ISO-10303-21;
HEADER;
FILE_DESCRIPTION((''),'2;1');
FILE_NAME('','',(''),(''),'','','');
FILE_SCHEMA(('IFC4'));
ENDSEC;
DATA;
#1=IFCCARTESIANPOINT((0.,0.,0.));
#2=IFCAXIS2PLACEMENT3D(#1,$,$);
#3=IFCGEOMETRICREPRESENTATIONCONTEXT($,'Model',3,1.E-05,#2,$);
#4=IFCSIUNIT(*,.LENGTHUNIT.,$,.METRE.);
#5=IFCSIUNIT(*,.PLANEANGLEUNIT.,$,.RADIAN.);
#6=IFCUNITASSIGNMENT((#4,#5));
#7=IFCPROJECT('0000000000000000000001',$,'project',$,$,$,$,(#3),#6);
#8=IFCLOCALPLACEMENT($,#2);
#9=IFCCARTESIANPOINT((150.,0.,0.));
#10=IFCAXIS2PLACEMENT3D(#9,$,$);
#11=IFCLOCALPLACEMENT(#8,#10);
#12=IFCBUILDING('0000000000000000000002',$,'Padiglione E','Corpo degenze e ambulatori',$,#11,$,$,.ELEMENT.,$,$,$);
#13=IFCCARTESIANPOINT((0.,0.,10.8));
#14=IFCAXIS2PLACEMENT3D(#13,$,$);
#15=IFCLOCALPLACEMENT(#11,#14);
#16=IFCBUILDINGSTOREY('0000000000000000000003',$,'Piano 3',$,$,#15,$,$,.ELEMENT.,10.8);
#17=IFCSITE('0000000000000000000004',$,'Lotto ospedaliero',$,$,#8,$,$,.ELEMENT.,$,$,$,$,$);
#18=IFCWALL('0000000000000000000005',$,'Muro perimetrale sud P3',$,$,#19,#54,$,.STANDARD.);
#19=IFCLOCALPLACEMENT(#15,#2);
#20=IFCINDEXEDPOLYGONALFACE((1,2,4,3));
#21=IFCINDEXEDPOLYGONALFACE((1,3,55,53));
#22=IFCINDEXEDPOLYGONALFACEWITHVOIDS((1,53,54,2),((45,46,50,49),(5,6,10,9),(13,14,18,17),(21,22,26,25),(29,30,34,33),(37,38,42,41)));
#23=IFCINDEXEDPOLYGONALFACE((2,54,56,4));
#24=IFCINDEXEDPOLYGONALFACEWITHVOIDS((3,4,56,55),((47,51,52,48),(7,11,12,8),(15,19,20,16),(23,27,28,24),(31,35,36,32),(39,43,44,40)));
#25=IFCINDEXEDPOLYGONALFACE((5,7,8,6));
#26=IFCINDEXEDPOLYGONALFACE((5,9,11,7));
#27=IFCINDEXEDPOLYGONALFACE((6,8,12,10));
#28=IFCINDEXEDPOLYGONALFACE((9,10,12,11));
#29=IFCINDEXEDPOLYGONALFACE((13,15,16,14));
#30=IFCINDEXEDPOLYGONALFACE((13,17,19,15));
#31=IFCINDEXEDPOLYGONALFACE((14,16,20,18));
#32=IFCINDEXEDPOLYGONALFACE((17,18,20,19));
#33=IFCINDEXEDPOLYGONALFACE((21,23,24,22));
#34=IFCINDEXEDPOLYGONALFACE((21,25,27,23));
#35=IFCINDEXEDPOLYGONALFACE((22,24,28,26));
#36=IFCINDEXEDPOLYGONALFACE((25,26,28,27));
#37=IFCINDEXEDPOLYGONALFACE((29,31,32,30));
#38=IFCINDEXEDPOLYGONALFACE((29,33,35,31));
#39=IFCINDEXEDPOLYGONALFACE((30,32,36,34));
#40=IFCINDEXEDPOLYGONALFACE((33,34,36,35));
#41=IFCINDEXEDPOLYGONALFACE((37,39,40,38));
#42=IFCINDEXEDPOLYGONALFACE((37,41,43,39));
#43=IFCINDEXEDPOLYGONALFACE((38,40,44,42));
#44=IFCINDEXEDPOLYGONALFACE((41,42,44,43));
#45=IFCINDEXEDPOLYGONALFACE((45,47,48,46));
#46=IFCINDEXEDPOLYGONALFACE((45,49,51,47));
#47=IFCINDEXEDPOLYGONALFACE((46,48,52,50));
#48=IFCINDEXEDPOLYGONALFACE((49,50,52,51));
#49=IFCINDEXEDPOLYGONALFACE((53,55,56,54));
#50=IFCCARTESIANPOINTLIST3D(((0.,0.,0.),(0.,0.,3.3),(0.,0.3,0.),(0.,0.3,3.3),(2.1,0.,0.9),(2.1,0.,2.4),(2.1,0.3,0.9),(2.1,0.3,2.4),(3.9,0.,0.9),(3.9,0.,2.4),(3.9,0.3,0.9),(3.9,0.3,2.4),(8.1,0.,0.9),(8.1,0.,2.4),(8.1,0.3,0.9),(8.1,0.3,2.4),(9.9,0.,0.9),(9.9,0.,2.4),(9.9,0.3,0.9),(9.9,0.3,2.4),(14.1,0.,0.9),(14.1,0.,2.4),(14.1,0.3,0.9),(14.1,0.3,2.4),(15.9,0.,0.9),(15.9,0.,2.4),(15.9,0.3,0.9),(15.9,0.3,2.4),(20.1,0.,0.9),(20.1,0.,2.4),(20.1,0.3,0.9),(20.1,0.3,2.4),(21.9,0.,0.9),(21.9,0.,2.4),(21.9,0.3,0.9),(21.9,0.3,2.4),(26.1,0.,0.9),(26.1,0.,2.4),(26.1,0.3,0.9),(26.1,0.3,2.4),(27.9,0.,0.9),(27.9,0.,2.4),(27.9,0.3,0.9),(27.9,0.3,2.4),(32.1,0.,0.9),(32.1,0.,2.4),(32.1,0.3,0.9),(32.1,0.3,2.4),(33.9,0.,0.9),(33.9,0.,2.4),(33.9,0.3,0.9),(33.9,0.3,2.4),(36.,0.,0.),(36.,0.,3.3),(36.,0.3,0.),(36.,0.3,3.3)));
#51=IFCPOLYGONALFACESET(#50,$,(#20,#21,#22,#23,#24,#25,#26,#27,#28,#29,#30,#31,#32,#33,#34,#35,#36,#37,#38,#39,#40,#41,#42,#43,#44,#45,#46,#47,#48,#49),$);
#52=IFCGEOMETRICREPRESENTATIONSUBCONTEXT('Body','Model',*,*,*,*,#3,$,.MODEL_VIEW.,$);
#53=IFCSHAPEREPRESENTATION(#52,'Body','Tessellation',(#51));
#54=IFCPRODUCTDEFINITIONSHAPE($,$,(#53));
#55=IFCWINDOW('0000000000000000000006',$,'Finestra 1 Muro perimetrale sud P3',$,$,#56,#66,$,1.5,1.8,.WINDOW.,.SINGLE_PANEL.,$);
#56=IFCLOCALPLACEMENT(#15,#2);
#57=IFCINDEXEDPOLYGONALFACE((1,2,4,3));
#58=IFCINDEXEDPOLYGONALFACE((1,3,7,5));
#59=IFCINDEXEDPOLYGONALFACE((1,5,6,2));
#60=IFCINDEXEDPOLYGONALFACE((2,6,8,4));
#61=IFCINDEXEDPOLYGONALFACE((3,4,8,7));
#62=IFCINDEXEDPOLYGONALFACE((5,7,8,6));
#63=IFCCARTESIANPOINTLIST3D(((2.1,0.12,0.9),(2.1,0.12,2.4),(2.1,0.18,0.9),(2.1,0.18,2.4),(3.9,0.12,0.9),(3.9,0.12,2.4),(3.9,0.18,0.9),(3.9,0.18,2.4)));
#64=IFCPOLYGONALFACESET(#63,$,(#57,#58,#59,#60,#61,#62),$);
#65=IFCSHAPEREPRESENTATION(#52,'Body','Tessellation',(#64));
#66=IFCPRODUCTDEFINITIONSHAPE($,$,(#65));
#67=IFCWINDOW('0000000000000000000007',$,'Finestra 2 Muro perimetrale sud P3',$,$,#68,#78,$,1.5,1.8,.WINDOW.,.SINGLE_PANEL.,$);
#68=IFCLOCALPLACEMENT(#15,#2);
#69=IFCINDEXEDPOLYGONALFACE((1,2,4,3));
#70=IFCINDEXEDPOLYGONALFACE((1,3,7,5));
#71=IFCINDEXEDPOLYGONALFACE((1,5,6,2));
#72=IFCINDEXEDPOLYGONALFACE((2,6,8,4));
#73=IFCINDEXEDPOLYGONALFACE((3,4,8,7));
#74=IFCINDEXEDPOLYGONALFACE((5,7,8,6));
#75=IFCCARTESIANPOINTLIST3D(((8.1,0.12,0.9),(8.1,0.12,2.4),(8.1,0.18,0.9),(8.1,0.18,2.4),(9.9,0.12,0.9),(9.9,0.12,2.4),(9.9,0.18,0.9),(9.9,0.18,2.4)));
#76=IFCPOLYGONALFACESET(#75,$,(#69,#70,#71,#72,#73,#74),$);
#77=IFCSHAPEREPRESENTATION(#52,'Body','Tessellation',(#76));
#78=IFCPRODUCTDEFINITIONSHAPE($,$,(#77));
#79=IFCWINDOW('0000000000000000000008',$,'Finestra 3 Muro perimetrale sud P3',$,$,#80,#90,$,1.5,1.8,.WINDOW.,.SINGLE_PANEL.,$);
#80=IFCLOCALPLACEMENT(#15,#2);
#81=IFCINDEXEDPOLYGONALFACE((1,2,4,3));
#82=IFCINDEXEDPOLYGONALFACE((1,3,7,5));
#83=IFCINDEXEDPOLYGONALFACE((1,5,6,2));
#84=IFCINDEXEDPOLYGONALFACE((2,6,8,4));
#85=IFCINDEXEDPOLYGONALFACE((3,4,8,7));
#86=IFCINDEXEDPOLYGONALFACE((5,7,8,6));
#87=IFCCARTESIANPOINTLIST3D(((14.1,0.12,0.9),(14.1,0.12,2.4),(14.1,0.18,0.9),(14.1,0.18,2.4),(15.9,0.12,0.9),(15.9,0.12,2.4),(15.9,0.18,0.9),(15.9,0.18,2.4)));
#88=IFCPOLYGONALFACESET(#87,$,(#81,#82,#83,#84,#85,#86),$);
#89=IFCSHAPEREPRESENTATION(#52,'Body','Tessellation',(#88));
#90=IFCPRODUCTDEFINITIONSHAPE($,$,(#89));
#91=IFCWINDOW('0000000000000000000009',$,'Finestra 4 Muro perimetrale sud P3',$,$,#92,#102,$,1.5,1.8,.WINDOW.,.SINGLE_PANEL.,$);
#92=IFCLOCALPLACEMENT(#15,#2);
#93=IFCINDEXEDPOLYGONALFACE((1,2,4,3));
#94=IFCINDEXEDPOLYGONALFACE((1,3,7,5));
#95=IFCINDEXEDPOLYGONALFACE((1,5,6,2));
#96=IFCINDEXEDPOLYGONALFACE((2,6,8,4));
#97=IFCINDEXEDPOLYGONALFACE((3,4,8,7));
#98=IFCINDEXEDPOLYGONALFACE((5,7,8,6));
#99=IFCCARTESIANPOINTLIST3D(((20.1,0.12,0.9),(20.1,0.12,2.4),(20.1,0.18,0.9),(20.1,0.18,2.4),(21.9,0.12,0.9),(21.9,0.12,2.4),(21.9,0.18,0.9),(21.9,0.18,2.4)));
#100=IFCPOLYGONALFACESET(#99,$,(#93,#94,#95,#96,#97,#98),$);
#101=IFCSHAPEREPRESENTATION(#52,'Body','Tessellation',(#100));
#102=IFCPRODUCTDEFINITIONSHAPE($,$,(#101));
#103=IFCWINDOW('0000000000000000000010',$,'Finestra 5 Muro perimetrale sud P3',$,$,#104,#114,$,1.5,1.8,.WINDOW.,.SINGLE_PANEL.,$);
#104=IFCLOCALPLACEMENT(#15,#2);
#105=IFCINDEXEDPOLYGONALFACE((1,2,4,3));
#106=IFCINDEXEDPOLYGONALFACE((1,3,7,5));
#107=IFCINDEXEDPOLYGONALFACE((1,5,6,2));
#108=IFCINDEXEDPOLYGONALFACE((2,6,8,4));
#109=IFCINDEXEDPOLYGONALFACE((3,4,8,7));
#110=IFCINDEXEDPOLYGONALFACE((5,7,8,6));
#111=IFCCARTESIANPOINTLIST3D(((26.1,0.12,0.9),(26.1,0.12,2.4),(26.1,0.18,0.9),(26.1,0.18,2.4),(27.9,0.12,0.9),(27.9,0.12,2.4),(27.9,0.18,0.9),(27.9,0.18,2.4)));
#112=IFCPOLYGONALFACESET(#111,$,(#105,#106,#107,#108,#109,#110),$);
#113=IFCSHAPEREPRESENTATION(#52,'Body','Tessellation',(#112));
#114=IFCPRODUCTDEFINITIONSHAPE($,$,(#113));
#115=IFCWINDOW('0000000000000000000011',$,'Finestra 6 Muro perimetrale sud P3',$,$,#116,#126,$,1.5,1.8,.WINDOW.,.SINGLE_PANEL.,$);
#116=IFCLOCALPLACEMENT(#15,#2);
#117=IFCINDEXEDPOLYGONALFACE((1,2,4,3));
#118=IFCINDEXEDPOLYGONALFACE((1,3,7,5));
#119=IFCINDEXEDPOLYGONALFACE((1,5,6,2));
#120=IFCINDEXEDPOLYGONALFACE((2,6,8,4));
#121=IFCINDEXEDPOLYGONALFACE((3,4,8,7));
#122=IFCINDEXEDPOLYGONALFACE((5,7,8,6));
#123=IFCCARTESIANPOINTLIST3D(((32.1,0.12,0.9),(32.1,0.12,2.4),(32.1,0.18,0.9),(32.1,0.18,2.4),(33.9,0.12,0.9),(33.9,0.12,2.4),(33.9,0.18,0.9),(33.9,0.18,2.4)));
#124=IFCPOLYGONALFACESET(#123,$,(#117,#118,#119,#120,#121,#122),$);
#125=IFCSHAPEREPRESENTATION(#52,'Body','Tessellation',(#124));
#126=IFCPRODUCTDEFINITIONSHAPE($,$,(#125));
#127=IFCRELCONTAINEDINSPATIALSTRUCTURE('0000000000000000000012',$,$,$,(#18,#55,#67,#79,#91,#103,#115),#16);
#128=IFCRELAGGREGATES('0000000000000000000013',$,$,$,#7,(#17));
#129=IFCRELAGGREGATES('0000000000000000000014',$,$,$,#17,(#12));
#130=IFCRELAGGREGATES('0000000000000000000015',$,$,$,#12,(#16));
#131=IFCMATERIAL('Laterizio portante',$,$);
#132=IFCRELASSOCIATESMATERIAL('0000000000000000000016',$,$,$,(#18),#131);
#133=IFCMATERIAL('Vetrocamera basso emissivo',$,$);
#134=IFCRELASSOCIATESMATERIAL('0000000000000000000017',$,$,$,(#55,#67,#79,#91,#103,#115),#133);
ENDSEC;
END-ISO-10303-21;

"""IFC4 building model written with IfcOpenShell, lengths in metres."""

from ifc_helpers import new_model, si_unit, frame, frame_2d, origin, place, context, subcontext, project, spatial, rectangle, extrude, material, element, fill, save


model = new_model("IFC4")

# Units and contexts
model_context = context("Model", 3, precision=1e-05, world=origin())
body_context = subcontext(model_context, "Body", "Model", "MODEL_VIEW")
ifc_project = project(units=[si_unit("LENGTHUNIT", "METRE"), si_unit("PLANEANGLEUNIT", "RADIAN")], contexts=[model_context])

# Site, building, storey
site_placement = place(None, origin())
site = spatial("IfcSite", under=ifc_project, at=site_placement, Name="Lotto ospedaliero", CompositionType="ELEMENT")
building_placement = place(site_placement, frame((150.0, 0.0, 0.0)))
building = spatial("IfcBuilding", under=site, at=building_placement, Name="Padiglione E", Description="Corpo degenze e ambulatori", CompositionType="ELEMENT")
storey_placement = place(building_placement, frame((0.0, 0.0, 10.8)))
storey = spatial("IfcBuildingStorey", under=building, at=storey_placement, Name="Piano 3", CompositionType="ELEMENT", Elevation=10.8)

# Wall, openings, windows
ifc_material_1 = material(Name="Laterizio portante")
wall_1_placement = place(storey_placement, origin())
wall_1 = element("IfcWall", 1, at=wall_1_placement, inside=storey, material=ifc_material_1, Name="Muro perimetrale sud P3", PredefinedType="STANDARD", context=body_context, shape_type="SweptSolid", body=[
    extrude(rectangle(XDim=36.0, YDim=0.3, at=frame_2d((18.0, 0.15))), origin(), (0.0, 0.0, 1.0), 3.3),
])
opening_1_placement = place(wall_1_placement, frame((2.1, -0.1, 0.9)))
opening_1 = element("IfcOpeningElement", 2, at=opening_1_placement, cuts=wall_1, PredefinedType="OPENING", context=body_context, shape_type="SweptSolid", body=[
    extrude(rectangle(XDim=1.8, YDim=0.5, at=frame_2d((0.9, 0.25))), origin(), (0.0, 0.0, 1.0), 1.5),
])
opening_2_placement = place(wall_1_placement, frame((8.1, -0.1, 0.9)))
opening_2 = element("IfcOpeningElement", 3, at=opening_2_placement, cuts=wall_1, PredefinedType="OPENING", context=body_context, shape_type="SweptSolid", body=[
    extrude(rectangle(XDim=1.8, YDim=0.5, at=frame_2d((0.9, 0.25))), origin(), (0.0, 0.0, 1.0), 1.5),
])
opening_3_placement = place(wall_1_placement, frame((14.1, -0.1, 0.9)))
opening_3 = element("IfcOpeningElement", 4, at=opening_3_placement, cuts=wall_1, PredefinedType="OPENING", context=body_context, shape_type="SweptSolid", body=[
    extrude(rectangle(XDim=1.8, YDim=0.5, at=frame_2d((0.9, 0.25))), origin(), (0.0, 0.0, 1.0), 1.5),
])
opening_4_placement = place(wall_1_placement, frame((20.1, -0.1, 0.9)))
opening_4 = element("IfcOpeningElement", 5, at=opening_4_placement, cuts=wall_1, PredefinedType="OPENING", context=body_context, shape_type="SweptSolid", body=[
    extrude(rectangle(XDim=1.8, YDim=0.5, at=frame_2d((0.9, 0.25))), origin(), (0.0, 0.0, 1.0), 1.5),
])
opening_5_placement = place(wall_1_placement, frame((26.1, -0.1, 0.9)))
opening_5 = element("IfcOpeningElement", 6, at=opening_5_placement, cuts=wall_1, PredefinedType="OPENING", context=body_context, shape_type="SweptSolid", body=[
    extrude(rectangle(XDim=1.8, YDim=0.5, at=frame_2d((0.9, 0.25))), origin(), (0.0, 0.0, 1.0), 1.5),
])
opening_6_placement = place(wall_1_placement, frame((32.1, -0.1, 0.9)))
opening_6 = element("IfcOpeningElement", 7, at=opening_6_placement, cuts=wall_1, PredefinedType="OPENING", context=body_context, shape_type="SweptSolid", body=[
    extrude(rectangle(XDim=1.8, YDim=0.5, at=frame_2d((0.9, 0.25))), origin(), (0.0, 0.0, 1.0), 1.5),
])
ifc_material_2 = material(Name="Vetrocamera basso emissivo")
window_1_placement = place(wall_1_placement, frame((2.1, 0.12, 0.9)))
window_1 = element("IfcWindow", 8, at=window_1_placement, inside=storey, material=ifc_material_2, Name="Finestra 1 Muro perimetrale sud P3", OverallHeight=1.5, OverallWidth=1.8, PartitioningType="SINGLE_PANEL", PredefinedType="WINDOW", context=body_context, shape_type="SweptSolid", body=[
    extrude(rectangle(XDim=1.8, YDim=0.06, at=frame_2d((0.9, 0.03))), origin(), (0.0, 0.0, 1.0), 1.5),
])
fill(opening_1, window_1)
window_2_placement = place(wall_1_placement, frame((8.1, 0.12, 0.9)))
window_2 = element("IfcWindow", 9, at=window_2_placement, inside=storey, material=ifc_material_2, Name="Finestra 2 Muro perimetrale sud P3", OverallHeight=1.5, OverallWidth=1.8, PartitioningType="SINGLE_PANEL", PredefinedType="WINDOW", context=body_context, shape_type="SweptSolid", body=[
    extrude(rectangle(XDim=1.8, YDim=0.06, at=frame_2d((0.9, 0.03))), origin(), (0.0, 0.0, 1.0), 1.5),
])
fill(opening_2, window_2)
window_3_placement = place(wall_1_placement, frame((14.1, 0.12, 0.9)))
window_3 = element("IfcWindow", 10, at=window_3_placement, inside=storey, material=ifc_material_2, Name="Finestra 3 Muro perimetrale sud P3", OverallHeight=1.5, OverallWidth=1.8, PartitioningType="SINGLE_PANEL", PredefinedType="WINDOW", context=body_context, shape_type="SweptSolid", body=[
    extrude(rectangle(XDim=1.8, YDim=0.06, at=frame_2d((0.9, 0.03))), origin(), (0.0, 0.0, 1.0), 1.5),
])
fill(opening_3, window_3)
window_4_placement = place(wall_1_placement, frame((20.1, 0.12, 0.9)))
window_4 = element("IfcWindow", 11, at=window_4_placement, inside=storey, material=ifc_material_2, Name="Finestra 4 Muro perimetrale sud P3", OverallHeight=1.5, OverallWidth=1.8, PartitioningType="SINGLE_PANEL", PredefinedType="WINDOW", context=body_context, shape_type="SweptSolid", body=[
    extrude(rectangle(XDim=1.8, YDim=0.06, at=frame_2d((0.9, 0.03))), origin(), (0.0, 0.0, 1.0), 1.5),
])
fill(opening_4, window_4)
window_5_placement = place(wall_1_placement, frame((26.1, 0.12, 0.9)))
window_5 = element("IfcWindow", 12, at=window_5_placement, inside=storey, material=ifc_material_2, Name="Finestra 5 Muro perimetrale sud P3", OverallHeight=1.5, OverallWidth=1.8, PartitioningType="SINGLE_PANEL", PredefinedType="WINDOW", context=body_context, shape_type="SweptSolid", body=[
    extrude(rectangle(XDim=1.8, YDim=0.06, at=frame_2d((0.9, 0.03))), origin(), (0.0, 0.0, 1.0), 1.5),
])
fill(opening_5, window_5)
window_6_placement = place(wall_1_placement, frame((32.1, 0.12, 0.9)))
window_6 = element("IfcWindow", 13, at=window_6_placement, inside=storey, material=ifc_material_2, Name="Finestra 6 Muro perimetrale sud P3", OverallHeight=1.5, OverallWidth=1.8, PartitioningType="SINGLE_PANEL", PredefinedType="WINDOW", context=body_context, shape_type="SweptSolid", body=[
    extrude(rectangle(XDim=1.8, YDim=0.06, at=frame_2d((0.9, 0.03))), origin(), (0.0, 0.0, 1.0), 1.5),
])
fill(opening_6, window_6)

save(model, "model.ifc")
